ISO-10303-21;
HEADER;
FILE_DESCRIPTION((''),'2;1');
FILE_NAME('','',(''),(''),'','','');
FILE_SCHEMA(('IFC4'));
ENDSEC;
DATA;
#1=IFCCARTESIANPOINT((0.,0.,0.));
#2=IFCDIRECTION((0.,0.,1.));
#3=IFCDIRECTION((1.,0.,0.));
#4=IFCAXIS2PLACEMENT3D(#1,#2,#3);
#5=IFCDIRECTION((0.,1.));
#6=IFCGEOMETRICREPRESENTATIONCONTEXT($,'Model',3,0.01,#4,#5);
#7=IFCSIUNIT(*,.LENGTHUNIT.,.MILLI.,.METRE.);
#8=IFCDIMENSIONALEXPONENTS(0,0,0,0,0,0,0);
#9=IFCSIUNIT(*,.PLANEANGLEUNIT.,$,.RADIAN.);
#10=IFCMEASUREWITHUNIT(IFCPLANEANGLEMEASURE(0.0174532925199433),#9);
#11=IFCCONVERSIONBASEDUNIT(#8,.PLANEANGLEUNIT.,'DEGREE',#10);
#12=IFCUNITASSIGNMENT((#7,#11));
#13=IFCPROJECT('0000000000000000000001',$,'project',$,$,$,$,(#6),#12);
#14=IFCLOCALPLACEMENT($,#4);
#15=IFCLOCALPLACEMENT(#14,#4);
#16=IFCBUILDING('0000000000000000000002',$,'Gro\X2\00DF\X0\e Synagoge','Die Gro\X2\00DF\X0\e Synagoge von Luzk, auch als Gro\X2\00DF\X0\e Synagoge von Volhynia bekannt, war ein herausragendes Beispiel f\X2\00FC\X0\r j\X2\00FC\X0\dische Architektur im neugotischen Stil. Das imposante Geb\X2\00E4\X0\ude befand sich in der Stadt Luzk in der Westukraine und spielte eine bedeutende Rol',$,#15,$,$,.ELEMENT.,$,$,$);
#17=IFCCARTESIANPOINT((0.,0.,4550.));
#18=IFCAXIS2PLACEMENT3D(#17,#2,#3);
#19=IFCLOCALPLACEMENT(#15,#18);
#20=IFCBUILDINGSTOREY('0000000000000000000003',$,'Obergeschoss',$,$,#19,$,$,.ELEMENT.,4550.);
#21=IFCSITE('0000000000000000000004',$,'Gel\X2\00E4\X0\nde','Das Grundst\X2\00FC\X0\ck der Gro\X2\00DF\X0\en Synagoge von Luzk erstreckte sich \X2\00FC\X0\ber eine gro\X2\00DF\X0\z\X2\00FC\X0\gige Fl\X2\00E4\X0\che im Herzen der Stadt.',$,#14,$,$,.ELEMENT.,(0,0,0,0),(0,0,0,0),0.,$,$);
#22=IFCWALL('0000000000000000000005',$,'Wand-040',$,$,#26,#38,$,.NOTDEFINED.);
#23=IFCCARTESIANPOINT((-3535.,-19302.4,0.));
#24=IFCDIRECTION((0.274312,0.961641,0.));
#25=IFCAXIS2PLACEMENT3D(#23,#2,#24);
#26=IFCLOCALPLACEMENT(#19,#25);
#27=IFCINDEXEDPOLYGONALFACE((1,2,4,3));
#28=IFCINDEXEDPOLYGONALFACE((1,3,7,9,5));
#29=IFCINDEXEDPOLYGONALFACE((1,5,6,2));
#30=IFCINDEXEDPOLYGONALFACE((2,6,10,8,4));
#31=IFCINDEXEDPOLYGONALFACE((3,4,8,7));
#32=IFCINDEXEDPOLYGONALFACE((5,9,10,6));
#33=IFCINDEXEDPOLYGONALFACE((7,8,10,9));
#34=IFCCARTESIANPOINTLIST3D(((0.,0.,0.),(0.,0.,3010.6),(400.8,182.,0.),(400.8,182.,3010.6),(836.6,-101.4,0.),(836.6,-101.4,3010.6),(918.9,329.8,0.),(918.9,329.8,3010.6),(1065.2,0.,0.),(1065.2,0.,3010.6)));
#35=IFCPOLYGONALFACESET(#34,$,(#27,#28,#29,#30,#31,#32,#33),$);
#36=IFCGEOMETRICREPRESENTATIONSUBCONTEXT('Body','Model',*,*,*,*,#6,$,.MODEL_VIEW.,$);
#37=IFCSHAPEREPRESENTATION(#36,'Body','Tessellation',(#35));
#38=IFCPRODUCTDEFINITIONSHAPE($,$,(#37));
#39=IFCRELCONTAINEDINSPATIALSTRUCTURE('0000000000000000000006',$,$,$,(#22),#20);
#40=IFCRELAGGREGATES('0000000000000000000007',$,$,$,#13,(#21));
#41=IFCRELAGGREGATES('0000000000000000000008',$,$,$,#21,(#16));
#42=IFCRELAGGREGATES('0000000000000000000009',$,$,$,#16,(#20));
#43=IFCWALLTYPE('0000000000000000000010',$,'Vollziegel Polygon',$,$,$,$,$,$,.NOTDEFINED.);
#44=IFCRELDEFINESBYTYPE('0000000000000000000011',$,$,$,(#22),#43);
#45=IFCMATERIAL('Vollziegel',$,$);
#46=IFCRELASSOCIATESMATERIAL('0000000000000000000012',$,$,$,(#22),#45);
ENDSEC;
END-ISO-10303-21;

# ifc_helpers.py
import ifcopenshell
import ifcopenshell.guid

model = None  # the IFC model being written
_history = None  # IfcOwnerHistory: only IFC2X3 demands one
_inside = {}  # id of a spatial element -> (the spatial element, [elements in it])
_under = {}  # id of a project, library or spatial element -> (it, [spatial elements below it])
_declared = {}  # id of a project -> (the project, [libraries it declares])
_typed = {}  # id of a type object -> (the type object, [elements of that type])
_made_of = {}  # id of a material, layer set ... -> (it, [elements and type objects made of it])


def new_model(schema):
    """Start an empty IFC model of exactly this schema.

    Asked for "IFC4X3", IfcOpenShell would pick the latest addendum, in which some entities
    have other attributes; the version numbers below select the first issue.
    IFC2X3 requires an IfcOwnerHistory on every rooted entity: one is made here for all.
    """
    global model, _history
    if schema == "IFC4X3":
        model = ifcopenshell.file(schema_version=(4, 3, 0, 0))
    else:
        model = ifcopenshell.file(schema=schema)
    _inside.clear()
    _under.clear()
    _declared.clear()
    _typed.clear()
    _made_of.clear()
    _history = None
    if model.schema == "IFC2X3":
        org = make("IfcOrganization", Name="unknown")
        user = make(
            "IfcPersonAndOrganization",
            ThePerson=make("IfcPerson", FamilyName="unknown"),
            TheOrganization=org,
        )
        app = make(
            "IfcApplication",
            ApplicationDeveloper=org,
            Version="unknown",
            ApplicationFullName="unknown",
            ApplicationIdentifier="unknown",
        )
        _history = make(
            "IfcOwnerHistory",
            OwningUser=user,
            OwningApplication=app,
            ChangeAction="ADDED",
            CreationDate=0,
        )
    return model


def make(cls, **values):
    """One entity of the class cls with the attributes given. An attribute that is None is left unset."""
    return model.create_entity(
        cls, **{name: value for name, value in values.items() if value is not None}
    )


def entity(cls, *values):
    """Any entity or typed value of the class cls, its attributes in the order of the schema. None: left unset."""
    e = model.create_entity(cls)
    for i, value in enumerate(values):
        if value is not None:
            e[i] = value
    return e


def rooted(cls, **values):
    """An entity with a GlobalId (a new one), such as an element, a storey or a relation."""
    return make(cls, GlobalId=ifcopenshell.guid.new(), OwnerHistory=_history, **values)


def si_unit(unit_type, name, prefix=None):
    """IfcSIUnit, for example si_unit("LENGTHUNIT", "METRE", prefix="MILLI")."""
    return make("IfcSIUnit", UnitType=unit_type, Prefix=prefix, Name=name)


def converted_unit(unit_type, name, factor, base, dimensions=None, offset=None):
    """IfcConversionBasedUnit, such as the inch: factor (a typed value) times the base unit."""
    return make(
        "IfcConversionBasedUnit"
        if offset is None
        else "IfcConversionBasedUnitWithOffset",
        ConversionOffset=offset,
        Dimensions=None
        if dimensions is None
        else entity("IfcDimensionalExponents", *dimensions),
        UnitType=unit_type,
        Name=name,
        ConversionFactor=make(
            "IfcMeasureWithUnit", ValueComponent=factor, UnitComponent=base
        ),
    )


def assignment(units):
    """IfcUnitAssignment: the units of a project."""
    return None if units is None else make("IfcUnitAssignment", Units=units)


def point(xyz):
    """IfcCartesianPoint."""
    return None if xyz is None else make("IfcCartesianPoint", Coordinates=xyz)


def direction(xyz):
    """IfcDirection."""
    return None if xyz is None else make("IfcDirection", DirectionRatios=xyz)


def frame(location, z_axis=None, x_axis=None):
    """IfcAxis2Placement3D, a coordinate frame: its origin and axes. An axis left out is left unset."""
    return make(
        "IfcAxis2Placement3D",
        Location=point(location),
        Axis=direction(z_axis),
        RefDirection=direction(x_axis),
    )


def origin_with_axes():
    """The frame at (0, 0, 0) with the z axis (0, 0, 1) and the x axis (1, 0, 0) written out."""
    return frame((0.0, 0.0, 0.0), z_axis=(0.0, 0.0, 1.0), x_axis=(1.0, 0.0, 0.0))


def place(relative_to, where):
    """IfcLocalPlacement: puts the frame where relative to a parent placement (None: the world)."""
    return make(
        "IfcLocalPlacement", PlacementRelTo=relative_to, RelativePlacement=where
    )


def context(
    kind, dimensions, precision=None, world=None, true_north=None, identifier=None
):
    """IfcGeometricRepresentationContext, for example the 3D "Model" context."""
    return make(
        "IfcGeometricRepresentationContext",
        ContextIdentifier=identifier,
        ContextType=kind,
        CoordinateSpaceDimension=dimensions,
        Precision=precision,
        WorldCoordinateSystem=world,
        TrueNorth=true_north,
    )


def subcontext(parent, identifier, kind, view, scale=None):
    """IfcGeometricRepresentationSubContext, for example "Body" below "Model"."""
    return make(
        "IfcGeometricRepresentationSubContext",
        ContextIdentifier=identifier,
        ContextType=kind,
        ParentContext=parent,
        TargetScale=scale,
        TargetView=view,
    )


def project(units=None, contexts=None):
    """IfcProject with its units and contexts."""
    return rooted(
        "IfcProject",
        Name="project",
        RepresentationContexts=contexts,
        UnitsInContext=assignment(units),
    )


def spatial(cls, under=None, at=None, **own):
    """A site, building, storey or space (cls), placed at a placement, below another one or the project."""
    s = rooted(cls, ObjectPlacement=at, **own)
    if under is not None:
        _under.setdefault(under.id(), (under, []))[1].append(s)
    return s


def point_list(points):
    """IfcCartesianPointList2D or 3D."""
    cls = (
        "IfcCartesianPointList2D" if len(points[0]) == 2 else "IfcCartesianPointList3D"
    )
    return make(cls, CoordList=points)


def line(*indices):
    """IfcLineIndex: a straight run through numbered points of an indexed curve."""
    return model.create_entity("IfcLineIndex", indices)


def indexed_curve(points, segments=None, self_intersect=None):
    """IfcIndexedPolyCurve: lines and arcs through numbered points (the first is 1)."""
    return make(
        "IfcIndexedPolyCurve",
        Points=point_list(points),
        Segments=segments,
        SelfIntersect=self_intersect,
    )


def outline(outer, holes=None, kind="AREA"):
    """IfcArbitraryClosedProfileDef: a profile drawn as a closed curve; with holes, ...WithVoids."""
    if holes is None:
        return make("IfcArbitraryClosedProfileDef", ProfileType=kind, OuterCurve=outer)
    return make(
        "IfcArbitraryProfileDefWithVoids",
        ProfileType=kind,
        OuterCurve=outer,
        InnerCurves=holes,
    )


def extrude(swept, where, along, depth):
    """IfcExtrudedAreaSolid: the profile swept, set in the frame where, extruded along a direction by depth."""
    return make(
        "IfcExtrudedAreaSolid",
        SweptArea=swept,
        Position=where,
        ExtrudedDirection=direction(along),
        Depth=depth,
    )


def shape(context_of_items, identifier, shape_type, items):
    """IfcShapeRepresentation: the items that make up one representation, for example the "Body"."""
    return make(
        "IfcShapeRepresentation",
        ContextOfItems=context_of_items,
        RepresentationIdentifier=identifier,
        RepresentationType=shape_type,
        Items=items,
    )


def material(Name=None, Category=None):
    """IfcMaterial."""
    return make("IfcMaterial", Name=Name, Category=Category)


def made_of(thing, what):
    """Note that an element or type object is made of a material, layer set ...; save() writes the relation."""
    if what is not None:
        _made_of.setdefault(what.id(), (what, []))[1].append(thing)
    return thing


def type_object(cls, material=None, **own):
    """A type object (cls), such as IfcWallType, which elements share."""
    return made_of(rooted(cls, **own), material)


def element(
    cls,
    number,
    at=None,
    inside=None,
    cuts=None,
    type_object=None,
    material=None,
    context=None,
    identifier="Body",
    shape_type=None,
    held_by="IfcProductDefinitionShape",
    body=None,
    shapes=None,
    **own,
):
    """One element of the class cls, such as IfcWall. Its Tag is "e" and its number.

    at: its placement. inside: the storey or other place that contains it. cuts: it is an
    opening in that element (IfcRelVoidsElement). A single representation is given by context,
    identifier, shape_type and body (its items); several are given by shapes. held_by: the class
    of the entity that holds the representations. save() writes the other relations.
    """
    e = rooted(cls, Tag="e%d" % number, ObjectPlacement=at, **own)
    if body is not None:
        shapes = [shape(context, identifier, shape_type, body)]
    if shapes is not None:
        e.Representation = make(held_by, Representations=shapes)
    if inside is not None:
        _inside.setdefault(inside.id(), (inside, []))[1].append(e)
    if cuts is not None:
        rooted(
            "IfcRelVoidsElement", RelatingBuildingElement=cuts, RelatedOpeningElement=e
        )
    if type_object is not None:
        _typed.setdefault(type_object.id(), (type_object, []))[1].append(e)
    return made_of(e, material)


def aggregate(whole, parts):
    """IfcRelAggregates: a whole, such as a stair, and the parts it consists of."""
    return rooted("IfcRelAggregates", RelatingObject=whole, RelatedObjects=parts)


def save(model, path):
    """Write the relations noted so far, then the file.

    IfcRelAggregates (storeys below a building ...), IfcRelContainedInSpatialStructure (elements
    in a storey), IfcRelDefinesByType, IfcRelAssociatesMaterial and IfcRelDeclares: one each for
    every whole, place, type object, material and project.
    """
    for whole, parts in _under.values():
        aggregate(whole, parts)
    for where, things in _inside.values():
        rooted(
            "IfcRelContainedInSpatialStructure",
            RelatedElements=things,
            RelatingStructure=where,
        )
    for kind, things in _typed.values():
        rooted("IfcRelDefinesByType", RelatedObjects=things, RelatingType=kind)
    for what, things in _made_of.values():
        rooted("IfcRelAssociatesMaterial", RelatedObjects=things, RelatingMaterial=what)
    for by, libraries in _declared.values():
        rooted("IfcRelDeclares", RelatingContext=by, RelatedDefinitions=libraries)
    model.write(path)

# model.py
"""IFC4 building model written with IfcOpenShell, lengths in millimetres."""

from ifc_helpers import new_model, entity, si_unit, converted_unit, direction, frame, origin_with_axes, place, context, subcontext, project, spatial, line, indexed_curve, outline, extrude, material, type_object, element, save


model = new_model("IFC4")

# Units and contexts
model_context = context("Model", 3, precision=0.01, world=origin_with_axes(), true_north=direction((0.0, 1.0)))
body_context = subcontext(model_context, "Body", "Model", "MODEL_VIEW")
ifc_project = project(units=[si_unit("LENGTHUNIT", "METRE", prefix="MILLI"), converted_unit("PLANEANGLEUNIT", "DEGREE", entity("IfcPlaneAngleMeasure", 0.0174532925199433), si_unit("PLANEANGLEUNIT", "RADIAN"), dimensions=[0, 0, 0, 0, 0, 0, 0])], contexts=[model_context])

# Site, building, storey
site_placement = place(None, origin_with_axes())
site = spatial("IfcSite", under=ifc_project, at=site_placement, Name="Gelände", Description="Das Grundstück der Großen Synagoge von Luzk erstreckte sich über eine großzügige Fläche im Herzen der Stadt.", CompositionType="ELEMENT", RefLatitude=(0, 0, 0, 0), RefLongitude=(0, 0, 0, 0), RefElevation=0.0)
building_placement = place(site_placement, origin_with_axes())
building = spatial("IfcBuilding", under=site, at=building_placement, Name="Große Synagoge", Description="Die Große Synagoge von Luzk, auch als Große Synagoge von Volhynia bekannt, war ein herausragendes Beispiel für jüdische Architektur im neugotischen Stil. Das imposante Gebäude befand sich in der Stadt Luzk in der Westukraine und spielte eine bedeutende Rol", CompositionType="ELEMENT")
storey_placement = place(building_placement, frame((0.0, 0.0, 4550.0), z_axis=(0.0, 0.0, 1.0), x_axis=(1.0, 0.0, 0.0)))
storey = spatial("IfcBuildingStorey", under=building, at=storey_placement, Name="Obergeschoss", CompositionType="ELEMENT", Elevation=4550.0)

# Wall
ifc_material_1 = material(Name="Vollziegel")
wall_type_1 = type_object("IfcWallType", Name="Vollziegel Polygon", PredefinedType="NOTDEFINED")
wall_1_placement = place(storey_placement, frame((-3535.0, -19302.4, 0.0), z_axis=(0.0, 0.0, 1.0), x_axis=(0.274312, 0.961641, 0.0)))
element("IfcWall", 1, at=wall_1_placement, inside=storey, type_object=wall_type_1, material=ifc_material_1, Name="Wand-040", PredefinedType="NOTDEFINED", context=body_context, shape_type="SweptSolid", body=[
    extrude(outline(indexed_curve([(0.0, 0.0), (836.6, -101.4), (1065.2, 0.0), (918.9, 329.8), (400.8, 182.0)], segments=[line(1, 2, 3, 4, 5, 1)])), origin_with_axes(), (0.0, 0.0, 1.0), 3010.6),
])

save(model, "model.ifc")
